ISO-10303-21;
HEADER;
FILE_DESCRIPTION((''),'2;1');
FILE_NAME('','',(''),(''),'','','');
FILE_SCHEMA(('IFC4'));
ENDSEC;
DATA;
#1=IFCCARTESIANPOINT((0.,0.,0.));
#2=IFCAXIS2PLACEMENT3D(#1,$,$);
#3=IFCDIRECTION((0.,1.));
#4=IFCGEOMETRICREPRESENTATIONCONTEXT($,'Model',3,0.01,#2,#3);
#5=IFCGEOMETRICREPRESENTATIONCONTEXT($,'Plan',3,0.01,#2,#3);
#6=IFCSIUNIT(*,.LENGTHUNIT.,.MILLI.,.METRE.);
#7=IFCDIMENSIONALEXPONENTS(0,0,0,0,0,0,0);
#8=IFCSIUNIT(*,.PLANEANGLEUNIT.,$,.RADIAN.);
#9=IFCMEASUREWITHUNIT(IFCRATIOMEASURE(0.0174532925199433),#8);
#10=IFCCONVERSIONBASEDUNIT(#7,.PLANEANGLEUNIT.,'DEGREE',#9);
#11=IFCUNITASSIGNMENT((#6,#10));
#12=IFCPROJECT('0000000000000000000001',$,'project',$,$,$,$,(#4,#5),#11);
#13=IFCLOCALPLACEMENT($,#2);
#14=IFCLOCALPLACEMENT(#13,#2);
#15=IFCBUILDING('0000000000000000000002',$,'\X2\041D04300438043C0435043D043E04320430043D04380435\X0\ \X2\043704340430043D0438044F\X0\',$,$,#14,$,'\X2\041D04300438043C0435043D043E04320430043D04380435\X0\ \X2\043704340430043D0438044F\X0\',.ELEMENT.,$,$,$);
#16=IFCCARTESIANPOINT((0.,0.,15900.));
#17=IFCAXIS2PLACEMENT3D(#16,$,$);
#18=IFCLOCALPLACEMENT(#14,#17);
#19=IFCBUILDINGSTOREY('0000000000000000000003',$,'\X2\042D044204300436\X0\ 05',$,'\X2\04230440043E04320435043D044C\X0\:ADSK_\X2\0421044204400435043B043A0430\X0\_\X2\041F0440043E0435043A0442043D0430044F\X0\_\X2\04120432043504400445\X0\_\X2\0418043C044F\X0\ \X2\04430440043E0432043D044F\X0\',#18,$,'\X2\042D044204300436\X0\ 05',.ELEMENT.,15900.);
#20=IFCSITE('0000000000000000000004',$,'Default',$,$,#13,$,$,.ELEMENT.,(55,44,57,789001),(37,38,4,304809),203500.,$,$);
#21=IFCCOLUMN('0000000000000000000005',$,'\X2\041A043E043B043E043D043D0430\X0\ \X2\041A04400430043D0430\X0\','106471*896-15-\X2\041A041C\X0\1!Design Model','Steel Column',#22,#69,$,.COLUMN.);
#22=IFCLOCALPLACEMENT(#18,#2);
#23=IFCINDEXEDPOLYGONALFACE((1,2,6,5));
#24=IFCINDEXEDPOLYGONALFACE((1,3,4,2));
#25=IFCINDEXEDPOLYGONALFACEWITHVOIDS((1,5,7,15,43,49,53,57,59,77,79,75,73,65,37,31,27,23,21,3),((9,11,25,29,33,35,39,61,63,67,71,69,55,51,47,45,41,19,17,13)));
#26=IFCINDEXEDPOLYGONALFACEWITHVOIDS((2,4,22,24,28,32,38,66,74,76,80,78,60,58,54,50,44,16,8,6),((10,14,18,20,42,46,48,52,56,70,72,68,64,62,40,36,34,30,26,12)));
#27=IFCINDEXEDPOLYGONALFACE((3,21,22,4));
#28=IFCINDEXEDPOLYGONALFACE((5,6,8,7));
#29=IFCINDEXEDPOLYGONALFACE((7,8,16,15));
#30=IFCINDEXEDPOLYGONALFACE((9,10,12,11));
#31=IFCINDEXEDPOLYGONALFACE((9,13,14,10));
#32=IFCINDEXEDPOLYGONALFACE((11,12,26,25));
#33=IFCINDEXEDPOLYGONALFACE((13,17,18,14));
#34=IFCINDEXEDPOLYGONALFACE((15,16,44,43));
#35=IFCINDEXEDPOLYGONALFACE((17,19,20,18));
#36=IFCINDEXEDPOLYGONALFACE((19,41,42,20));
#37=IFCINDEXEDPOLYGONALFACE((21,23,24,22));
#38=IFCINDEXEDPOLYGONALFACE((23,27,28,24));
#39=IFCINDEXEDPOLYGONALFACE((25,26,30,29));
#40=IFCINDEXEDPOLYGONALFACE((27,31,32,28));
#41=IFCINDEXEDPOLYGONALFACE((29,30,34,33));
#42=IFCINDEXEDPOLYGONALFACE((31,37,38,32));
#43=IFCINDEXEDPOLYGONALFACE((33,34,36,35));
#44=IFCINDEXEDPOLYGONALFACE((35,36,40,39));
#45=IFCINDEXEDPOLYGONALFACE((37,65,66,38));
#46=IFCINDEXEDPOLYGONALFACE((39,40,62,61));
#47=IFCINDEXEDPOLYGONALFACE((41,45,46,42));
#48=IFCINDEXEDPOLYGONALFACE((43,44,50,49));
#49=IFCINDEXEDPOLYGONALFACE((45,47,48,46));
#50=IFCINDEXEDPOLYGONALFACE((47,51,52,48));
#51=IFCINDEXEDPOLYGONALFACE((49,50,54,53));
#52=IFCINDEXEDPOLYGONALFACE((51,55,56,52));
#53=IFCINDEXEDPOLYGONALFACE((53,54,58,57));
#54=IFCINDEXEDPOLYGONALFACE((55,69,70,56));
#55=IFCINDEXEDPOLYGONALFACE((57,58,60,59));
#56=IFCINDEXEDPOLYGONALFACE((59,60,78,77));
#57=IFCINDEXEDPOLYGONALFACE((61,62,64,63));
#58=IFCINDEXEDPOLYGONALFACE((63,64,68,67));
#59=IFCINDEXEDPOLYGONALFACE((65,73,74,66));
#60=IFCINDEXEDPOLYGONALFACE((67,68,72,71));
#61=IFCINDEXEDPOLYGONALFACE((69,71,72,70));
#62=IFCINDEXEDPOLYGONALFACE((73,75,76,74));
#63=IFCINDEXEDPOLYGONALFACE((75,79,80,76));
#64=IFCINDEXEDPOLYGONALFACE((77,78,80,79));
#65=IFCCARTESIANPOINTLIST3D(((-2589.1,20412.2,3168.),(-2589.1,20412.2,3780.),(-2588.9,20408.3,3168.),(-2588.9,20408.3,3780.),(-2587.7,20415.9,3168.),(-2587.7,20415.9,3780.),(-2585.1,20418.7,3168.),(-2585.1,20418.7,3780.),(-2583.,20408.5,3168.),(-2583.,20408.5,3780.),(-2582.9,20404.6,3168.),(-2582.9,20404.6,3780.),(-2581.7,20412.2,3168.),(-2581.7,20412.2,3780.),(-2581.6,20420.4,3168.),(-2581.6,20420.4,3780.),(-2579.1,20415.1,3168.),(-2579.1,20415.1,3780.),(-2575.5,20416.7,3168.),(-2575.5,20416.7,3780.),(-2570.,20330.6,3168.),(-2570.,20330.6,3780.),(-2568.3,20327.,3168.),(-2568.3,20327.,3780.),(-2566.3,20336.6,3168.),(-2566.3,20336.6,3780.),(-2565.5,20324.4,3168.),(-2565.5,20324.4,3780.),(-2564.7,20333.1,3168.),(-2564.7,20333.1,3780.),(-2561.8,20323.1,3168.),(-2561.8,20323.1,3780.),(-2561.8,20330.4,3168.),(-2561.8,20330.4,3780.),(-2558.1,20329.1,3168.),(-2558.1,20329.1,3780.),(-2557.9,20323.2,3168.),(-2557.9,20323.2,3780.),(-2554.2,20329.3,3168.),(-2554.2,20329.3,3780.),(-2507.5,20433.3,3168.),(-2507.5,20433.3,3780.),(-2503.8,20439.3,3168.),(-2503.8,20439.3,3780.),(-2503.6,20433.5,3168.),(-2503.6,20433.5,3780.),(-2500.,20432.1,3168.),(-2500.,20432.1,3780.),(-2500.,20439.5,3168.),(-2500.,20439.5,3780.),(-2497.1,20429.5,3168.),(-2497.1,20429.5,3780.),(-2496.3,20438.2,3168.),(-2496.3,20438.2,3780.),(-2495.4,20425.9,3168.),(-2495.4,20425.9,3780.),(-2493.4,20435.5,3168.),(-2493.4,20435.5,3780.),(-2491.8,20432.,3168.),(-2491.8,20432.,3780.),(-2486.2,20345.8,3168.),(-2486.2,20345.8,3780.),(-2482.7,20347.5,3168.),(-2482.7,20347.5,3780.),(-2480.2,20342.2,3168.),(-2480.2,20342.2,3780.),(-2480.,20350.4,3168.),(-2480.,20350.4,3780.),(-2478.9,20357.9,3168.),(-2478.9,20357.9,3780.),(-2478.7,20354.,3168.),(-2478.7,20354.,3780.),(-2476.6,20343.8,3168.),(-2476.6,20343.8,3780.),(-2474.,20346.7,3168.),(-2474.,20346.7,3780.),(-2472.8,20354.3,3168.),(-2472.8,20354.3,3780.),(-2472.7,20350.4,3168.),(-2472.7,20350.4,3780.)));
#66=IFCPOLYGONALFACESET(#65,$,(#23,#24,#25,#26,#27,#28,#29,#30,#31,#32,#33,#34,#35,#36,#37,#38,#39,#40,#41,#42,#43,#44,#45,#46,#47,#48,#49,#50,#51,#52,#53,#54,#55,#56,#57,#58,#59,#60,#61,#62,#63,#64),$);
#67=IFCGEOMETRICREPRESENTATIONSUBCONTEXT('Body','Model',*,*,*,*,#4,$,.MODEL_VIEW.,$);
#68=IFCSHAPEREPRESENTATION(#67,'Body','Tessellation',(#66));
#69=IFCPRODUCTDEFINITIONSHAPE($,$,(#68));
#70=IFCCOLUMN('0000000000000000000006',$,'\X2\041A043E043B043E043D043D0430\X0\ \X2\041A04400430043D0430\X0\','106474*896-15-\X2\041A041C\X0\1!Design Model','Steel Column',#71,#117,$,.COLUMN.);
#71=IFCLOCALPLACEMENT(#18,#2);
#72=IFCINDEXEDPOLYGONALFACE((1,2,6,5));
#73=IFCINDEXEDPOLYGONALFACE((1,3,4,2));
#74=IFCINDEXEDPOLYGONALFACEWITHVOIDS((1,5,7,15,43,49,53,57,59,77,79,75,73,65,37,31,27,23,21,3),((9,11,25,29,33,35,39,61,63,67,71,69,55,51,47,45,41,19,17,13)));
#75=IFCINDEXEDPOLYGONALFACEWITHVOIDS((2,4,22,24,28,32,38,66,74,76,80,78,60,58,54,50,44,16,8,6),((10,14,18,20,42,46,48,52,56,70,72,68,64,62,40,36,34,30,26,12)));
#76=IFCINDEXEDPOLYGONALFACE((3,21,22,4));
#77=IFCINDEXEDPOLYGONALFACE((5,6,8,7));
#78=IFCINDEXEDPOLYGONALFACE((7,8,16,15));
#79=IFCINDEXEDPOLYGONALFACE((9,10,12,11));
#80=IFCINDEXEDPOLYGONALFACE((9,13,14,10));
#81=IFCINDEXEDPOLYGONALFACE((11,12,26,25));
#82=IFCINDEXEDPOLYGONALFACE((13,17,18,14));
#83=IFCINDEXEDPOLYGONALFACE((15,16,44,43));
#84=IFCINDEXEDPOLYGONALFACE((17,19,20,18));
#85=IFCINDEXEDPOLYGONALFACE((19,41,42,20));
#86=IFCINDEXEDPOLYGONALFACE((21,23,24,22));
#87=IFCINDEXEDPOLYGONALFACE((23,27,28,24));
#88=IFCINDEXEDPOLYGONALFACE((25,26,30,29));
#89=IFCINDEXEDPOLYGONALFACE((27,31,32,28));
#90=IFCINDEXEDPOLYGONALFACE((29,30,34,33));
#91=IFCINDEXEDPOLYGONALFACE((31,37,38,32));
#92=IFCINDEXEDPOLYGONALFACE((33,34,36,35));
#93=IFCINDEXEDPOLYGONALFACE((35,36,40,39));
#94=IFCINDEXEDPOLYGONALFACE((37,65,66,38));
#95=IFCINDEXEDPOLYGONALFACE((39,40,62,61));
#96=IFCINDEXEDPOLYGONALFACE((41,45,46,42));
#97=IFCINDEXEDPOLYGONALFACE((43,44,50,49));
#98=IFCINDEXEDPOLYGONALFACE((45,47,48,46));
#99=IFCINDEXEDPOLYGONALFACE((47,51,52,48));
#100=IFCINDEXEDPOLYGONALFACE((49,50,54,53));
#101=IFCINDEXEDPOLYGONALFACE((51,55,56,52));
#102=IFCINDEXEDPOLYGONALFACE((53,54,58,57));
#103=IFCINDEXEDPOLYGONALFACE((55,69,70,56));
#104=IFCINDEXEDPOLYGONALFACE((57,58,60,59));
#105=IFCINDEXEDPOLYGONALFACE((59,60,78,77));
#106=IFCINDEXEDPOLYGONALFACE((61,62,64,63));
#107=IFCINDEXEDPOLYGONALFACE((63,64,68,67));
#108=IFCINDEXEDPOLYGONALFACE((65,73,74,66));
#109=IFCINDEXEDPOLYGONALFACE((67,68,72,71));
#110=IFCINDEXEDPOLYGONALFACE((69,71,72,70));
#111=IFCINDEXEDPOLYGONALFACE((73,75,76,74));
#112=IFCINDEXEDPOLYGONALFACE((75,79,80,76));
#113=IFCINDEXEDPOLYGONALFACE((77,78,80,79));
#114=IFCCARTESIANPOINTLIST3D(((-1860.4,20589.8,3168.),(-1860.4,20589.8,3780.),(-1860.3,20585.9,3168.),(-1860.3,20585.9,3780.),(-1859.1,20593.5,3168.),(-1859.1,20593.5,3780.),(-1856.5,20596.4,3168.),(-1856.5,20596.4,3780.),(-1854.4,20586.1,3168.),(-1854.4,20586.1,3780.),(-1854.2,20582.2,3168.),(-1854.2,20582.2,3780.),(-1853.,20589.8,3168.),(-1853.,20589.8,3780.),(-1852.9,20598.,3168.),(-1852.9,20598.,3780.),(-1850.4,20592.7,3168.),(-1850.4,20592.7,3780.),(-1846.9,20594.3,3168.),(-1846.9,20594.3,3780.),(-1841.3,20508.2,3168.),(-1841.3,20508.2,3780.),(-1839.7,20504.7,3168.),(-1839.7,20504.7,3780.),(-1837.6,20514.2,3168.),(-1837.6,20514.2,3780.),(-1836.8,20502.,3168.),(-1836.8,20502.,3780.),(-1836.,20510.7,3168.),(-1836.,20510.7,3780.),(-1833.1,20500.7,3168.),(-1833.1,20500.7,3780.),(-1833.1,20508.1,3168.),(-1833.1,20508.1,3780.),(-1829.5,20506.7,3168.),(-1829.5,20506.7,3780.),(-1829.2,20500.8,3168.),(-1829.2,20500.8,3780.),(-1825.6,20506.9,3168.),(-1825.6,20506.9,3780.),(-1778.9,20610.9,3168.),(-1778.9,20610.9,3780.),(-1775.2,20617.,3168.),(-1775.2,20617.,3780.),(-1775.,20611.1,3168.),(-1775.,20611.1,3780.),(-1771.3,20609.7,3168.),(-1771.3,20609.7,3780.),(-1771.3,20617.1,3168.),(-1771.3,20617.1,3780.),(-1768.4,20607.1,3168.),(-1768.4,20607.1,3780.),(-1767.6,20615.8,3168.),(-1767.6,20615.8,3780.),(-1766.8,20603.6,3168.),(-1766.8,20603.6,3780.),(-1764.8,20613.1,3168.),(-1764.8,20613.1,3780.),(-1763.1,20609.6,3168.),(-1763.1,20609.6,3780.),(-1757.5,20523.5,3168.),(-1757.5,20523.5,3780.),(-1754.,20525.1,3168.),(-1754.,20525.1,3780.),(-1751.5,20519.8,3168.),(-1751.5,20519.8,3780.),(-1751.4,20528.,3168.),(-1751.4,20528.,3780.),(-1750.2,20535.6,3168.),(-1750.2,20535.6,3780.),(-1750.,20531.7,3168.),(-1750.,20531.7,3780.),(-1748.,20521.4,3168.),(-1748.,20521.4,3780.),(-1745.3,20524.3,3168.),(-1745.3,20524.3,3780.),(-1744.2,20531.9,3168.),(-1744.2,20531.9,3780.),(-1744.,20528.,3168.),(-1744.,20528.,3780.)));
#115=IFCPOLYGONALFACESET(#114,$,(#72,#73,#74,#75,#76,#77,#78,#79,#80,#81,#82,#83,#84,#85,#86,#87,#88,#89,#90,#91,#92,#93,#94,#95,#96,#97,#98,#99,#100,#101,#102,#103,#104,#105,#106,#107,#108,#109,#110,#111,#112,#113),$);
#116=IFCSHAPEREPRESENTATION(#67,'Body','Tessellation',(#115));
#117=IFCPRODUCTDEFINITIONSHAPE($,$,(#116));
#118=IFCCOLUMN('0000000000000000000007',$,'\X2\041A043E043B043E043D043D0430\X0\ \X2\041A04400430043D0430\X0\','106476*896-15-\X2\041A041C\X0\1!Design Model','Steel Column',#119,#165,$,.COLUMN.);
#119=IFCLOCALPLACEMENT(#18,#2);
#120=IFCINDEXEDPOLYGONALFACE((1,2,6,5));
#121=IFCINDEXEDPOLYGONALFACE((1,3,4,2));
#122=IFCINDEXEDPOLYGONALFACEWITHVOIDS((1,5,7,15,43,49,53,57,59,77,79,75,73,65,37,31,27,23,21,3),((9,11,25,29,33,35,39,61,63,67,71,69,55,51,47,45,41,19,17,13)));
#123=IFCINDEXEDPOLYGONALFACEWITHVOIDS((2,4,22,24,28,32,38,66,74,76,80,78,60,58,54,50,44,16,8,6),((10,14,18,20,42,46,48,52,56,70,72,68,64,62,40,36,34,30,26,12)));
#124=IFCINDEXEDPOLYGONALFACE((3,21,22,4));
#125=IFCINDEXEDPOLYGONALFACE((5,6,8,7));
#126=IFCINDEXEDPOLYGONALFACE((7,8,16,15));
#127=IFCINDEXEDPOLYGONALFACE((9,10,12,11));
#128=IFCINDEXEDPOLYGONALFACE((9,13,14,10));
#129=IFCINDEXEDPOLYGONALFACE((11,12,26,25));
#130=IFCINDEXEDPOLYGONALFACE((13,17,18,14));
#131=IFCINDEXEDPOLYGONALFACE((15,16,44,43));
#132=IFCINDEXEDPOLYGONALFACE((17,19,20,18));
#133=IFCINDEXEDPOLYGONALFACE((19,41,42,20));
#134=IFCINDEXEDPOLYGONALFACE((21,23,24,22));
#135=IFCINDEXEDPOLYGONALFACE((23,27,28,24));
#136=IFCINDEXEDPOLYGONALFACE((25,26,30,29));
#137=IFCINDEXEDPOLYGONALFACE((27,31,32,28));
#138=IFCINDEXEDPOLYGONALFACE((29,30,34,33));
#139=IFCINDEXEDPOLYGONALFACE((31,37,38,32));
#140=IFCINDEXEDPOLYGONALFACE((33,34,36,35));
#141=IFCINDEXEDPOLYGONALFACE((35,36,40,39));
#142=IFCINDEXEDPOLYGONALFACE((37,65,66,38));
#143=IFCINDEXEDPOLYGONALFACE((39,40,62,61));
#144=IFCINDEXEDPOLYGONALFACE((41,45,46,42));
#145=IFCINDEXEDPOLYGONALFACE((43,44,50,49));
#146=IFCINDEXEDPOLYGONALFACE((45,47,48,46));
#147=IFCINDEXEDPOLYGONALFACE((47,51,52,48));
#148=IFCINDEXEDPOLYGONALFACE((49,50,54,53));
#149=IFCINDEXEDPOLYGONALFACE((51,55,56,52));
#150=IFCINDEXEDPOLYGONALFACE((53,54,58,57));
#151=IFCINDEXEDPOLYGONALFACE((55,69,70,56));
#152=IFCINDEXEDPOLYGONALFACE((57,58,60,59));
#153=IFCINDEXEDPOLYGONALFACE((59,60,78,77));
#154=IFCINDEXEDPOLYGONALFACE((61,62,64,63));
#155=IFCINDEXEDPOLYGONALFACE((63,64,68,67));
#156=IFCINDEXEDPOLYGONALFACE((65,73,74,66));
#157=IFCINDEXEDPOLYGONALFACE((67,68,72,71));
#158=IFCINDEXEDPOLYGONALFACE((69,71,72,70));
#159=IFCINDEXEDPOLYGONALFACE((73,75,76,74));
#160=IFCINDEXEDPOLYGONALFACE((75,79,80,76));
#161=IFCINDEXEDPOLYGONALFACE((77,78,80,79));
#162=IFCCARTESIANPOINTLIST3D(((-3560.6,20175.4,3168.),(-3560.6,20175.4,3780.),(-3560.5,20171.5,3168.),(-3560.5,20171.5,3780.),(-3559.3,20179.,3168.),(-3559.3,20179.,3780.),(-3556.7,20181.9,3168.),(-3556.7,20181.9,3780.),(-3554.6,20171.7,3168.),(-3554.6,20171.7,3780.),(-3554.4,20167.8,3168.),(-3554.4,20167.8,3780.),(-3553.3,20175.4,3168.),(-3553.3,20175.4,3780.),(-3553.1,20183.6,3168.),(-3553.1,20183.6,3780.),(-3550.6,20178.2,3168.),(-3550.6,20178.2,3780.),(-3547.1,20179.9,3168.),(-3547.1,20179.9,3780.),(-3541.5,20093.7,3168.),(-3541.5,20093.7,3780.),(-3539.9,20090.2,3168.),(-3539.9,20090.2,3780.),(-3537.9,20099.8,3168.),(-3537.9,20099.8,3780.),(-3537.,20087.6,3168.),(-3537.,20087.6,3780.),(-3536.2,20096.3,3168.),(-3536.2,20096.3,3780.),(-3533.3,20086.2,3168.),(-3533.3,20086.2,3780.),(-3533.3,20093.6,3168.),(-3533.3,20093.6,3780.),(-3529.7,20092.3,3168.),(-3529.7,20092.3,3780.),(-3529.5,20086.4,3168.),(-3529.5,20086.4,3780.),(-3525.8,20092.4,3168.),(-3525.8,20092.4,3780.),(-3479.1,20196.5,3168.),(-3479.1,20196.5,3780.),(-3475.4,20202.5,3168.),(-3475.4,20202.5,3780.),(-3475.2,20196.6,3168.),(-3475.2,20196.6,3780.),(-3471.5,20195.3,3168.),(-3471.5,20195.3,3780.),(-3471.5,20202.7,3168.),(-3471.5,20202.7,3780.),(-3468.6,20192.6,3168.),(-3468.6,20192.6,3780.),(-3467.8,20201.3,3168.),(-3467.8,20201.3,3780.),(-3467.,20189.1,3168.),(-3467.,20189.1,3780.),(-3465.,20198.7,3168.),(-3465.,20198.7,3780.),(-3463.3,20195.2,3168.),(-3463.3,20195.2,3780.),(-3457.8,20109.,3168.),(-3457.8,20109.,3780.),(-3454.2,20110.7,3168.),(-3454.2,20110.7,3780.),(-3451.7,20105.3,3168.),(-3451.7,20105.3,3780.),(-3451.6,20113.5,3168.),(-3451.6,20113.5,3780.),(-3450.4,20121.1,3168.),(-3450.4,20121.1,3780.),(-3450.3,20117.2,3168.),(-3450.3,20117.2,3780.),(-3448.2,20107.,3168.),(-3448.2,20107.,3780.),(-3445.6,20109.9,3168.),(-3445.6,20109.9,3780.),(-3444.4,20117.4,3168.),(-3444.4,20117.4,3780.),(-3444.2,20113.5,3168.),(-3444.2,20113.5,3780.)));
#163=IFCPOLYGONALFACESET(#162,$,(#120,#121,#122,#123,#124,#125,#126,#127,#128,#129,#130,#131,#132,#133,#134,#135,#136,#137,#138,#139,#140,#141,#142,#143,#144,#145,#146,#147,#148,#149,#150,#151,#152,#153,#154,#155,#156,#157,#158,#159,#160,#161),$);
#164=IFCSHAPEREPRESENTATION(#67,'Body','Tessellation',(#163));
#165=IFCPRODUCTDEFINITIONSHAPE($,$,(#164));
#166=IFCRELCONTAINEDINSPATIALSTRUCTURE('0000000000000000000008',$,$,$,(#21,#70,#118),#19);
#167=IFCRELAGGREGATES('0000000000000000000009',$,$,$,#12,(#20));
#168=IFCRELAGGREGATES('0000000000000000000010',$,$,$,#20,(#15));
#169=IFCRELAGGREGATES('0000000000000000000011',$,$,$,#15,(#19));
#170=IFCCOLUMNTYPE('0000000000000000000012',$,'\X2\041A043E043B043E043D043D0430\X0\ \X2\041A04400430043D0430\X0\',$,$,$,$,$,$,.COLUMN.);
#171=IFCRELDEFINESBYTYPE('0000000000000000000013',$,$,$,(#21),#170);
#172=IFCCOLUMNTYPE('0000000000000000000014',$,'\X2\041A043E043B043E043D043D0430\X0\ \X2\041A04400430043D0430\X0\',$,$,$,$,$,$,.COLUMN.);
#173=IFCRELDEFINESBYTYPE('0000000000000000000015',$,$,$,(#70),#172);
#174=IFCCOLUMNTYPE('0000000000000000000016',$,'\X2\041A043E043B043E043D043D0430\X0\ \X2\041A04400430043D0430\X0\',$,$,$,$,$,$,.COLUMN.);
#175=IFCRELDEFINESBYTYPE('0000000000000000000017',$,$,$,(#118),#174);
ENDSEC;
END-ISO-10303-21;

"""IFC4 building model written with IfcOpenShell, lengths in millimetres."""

from ifc_helpers import new_model, entity, si_unit, converted_unit, direction, frame, origin, place, context, subcontext, project, spatial, indexed_curve, outline, extrude, type_object, element, save


model = new_model("IFC4")

# Units and contexts
model_context = context("Model", 3, precision=0.01, world=origin(), true_north=direction((0.0, 1.0)))
plan_context = context("Plan", 3, precision=0.01, world=origin(), true_north=direction((0.0, 1.0)))
body_context = subcontext(model_context, "Body", "Model", "MODEL_VIEW")
ifc_project = project(units=[si_unit("LENGTHUNIT", "METRE", prefix="MILLI"), converted_unit("PLANEANGLEUNIT", "DEGREE", entity("IfcRatioMeasure", 0.0174532925199433), si_unit("PLANEANGLEUNIT", "RADIAN"), dimensions=[0, 0, 0, 0, 0, 0, 0])], contexts=[model_context, plan_context])

# Site, building, storey
site_placement = place(None, origin())
site = spatial("IfcSite", under=ifc_project, at=site_placement, Name="Default", CompositionType="ELEMENT", RefLatitude=(55, 44, 57, 789001), RefLongitude=(37, 38, 4, 304809), RefElevation=203500.0)
building_placement = place(site_placement, origin())
building = spatial("IfcBuilding", under=site, at=building_placement, Name="Наименование здания", LongName="Наименование здания", CompositionType="ELEMENT")
storey_placement = place(building_placement, frame((0.0, 0.0, 15900.0)))
storey = spatial("IfcBuildingStorey", under=building, at=storey_placement, Name="Этаж 05", ObjectType="Уровень:ADSK_Стрелка_Проектная_Вверх_Имя уровня", LongName="Этаж 05", CompositionType="ELEMENT", Elevation=15900.0)

# Columns
placement = place(storey_placement, origin())
column_type_1 = type_object("IfcColumnType", Name="Колонна Крана", PredefinedType="COLUMN")
element("IfcColumn", 1, at=placement, inside=storey, type_object=column_type_1, Name="Колонна Крана", Description="106471*896-15-КМ1!Design Model", ObjectType="Steel Column", PredefinedType="COLUMN", context=body_context, shape_type="SweptSolid", body=[
    extrude(outline(indexed_curve([(29.5, -56.8), (33.4, -56.8), (37.0, -55.3), (39.7, -52.6), (41.2, -49.0), (56.8, 29.5), (56.8, 33.4), (55.3, 37.0), (52.6, 39.7), (49.0, 41.2), (-29.5, 56.8), (-33.4, 56.8), (-37.0, 55.3), (-39.7, 52.6), (-41.2, 49.0), (-56.8, -29.5), (-56.8, -33.4), (-55.3, -37.0), (-52.6, -39.7), (-49.0, -41.2), (29.5, -56.8)], self_intersect=False), holes=[indexed_curve([(-43.1, -37.3), (-46.7, -35.8), (-49.5, -33.1), (-51.0, -29.5), (-51.0, -25.5), (-37.3, 43.1), (-35.8, 46.7), (-33.1, 49.5), (-29.5, 51.0), (-25.5, 51.0), (43.1, 37.3), (46.7, 35.8), (49.5, 33.1), (51.0, 29.5), (51.0, 25.5), (37.3, -43.1), (35.8, -46.7), (33.1, -49.5), (29.5, -51.0), (25.5, -51.0), (-43.1, -37.3)], self_intersect=False)]), frame((-2530.9, 20381.3, 3168.0), z_axis=(0.0, 0.0, 1.0), x_axis=(0.906681, 0.421816, 0.0)), (0.0, 0.0, 1.0), 612.0),
])
column_type_2 = type_object("IfcColumnType", Name="Колонна Крана", PredefinedType="COLUMN")
element("IfcColumn", 2, at=placement, inside=storey, type_object=column_type_2, Name="Колонна Крана", Description="106474*896-15-КМ1!Design Model", ObjectType="Steel Column", PredefinedType="COLUMN", context=body_context, shape_type="SweptSolid", body=[
    extrude(outline(indexed_curve([(29.5, -56.8), (33.4, -56.8), (37.0, -55.3), (39.7, -52.6), (41.2, -49.0), (56.8, 29.5), (56.8, 33.4), (55.3, 37.0), (52.6, 39.7), (49.0, 41.2), (-29.5, 56.8), (-33.4, 56.8), (-37.0, 55.3), (-39.7, 52.6), (-41.2, 49.0), (-56.8, -29.5), (-56.8, -33.4), (-55.3, -37.0), (-52.6, -39.7), (-49.0, -41.2), (29.5, -56.8)], self_intersect=False), holes=[indexed_curve([(-43.1, -37.3), (-46.7, -35.8), (-49.5, -33.1), (-51.0, -29.5), (-51.0, -25.5), (-37.3, 43.1), (-35.8, 46.7), (-33.1, 49.5), (-29.5, 51.0), (-25.5, 51.0), (43.1, 37.3), (46.7, 35.8), (49.5, 33.1), (51.0, 29.5), (51.0, 25.5), (37.3, -43.1), (35.8, -46.7), (33.1, -49.5), (29.5, -51.0), (25.5, -51.0), (-43.1, -37.3)], self_intersect=False)]), frame((-1802.2, 20558.9, 3168.0), z_axis=(0.0, 0.0, 1.0), x_axis=(0.906681, 0.421816, 0.0)), (0.0, 0.0, 1.0), 612.0),
])
column_type_3 = type_object("IfcColumnType", Name="Колонна Крана", PredefinedType="COLUMN")
element("IfcColumn", 3, at=placement, inside=storey, type_object=column_type_3, Name="Колонна Крана", Description="106476*896-15-КМ1!Design Model", ObjectType="Steel Column", PredefinedType="COLUMN", context=body_context, shape_type="SweptSolid", body=[
    extrude(outline(indexed_curve([(29.5, -56.8), (33.4, -56.8), (37.0, -55.3), (39.7, -52.6), (41.2, -49.0), (56.8, 29.5), (56.8, 33.4), (55.3, 37.0), (52.6, 39.7), (49.0, 41.2), (-29.5, 56.8), (-33.4, 56.8), (-37.0, 55.3), (-39.7, 52.6), (-41.2, 49.0), (-56.8, -29.5), (-56.8, -33.4), (-55.3, -37.0), (-52.6, -39.7), (-49.0, -41.2), (29.5, -56.8)], self_intersect=False), holes=[indexed_curve([(-43.1, -37.3), (-46.7, -35.8), (-49.5, -33.1), (-51.0, -29.5), (-51.0, -25.5), (-37.3, 43.1), (-35.8, 46.7), (-33.1, 49.5), (-29.5, 51.0), (-25.5, 51.0), (43.1, 37.3), (46.7, 35.8), (49.5, 33.1), (51.0, 29.5), (51.0, 25.5), (37.3, -43.1), (35.8, -46.7), (33.1, -49.5), (29.5, -51.0), (25.5, -51.0), (-43.1, -37.3)], self_intersect=False)]), frame((-3502.4, 20144.5, 3168.0), z_axis=(0.0, 0.0, 1.0), x_axis=(0.906681, 0.421816, 0.0)), (0.0, 0.0, 1.0), 612.0),
])

save(model, "model.ifc")
